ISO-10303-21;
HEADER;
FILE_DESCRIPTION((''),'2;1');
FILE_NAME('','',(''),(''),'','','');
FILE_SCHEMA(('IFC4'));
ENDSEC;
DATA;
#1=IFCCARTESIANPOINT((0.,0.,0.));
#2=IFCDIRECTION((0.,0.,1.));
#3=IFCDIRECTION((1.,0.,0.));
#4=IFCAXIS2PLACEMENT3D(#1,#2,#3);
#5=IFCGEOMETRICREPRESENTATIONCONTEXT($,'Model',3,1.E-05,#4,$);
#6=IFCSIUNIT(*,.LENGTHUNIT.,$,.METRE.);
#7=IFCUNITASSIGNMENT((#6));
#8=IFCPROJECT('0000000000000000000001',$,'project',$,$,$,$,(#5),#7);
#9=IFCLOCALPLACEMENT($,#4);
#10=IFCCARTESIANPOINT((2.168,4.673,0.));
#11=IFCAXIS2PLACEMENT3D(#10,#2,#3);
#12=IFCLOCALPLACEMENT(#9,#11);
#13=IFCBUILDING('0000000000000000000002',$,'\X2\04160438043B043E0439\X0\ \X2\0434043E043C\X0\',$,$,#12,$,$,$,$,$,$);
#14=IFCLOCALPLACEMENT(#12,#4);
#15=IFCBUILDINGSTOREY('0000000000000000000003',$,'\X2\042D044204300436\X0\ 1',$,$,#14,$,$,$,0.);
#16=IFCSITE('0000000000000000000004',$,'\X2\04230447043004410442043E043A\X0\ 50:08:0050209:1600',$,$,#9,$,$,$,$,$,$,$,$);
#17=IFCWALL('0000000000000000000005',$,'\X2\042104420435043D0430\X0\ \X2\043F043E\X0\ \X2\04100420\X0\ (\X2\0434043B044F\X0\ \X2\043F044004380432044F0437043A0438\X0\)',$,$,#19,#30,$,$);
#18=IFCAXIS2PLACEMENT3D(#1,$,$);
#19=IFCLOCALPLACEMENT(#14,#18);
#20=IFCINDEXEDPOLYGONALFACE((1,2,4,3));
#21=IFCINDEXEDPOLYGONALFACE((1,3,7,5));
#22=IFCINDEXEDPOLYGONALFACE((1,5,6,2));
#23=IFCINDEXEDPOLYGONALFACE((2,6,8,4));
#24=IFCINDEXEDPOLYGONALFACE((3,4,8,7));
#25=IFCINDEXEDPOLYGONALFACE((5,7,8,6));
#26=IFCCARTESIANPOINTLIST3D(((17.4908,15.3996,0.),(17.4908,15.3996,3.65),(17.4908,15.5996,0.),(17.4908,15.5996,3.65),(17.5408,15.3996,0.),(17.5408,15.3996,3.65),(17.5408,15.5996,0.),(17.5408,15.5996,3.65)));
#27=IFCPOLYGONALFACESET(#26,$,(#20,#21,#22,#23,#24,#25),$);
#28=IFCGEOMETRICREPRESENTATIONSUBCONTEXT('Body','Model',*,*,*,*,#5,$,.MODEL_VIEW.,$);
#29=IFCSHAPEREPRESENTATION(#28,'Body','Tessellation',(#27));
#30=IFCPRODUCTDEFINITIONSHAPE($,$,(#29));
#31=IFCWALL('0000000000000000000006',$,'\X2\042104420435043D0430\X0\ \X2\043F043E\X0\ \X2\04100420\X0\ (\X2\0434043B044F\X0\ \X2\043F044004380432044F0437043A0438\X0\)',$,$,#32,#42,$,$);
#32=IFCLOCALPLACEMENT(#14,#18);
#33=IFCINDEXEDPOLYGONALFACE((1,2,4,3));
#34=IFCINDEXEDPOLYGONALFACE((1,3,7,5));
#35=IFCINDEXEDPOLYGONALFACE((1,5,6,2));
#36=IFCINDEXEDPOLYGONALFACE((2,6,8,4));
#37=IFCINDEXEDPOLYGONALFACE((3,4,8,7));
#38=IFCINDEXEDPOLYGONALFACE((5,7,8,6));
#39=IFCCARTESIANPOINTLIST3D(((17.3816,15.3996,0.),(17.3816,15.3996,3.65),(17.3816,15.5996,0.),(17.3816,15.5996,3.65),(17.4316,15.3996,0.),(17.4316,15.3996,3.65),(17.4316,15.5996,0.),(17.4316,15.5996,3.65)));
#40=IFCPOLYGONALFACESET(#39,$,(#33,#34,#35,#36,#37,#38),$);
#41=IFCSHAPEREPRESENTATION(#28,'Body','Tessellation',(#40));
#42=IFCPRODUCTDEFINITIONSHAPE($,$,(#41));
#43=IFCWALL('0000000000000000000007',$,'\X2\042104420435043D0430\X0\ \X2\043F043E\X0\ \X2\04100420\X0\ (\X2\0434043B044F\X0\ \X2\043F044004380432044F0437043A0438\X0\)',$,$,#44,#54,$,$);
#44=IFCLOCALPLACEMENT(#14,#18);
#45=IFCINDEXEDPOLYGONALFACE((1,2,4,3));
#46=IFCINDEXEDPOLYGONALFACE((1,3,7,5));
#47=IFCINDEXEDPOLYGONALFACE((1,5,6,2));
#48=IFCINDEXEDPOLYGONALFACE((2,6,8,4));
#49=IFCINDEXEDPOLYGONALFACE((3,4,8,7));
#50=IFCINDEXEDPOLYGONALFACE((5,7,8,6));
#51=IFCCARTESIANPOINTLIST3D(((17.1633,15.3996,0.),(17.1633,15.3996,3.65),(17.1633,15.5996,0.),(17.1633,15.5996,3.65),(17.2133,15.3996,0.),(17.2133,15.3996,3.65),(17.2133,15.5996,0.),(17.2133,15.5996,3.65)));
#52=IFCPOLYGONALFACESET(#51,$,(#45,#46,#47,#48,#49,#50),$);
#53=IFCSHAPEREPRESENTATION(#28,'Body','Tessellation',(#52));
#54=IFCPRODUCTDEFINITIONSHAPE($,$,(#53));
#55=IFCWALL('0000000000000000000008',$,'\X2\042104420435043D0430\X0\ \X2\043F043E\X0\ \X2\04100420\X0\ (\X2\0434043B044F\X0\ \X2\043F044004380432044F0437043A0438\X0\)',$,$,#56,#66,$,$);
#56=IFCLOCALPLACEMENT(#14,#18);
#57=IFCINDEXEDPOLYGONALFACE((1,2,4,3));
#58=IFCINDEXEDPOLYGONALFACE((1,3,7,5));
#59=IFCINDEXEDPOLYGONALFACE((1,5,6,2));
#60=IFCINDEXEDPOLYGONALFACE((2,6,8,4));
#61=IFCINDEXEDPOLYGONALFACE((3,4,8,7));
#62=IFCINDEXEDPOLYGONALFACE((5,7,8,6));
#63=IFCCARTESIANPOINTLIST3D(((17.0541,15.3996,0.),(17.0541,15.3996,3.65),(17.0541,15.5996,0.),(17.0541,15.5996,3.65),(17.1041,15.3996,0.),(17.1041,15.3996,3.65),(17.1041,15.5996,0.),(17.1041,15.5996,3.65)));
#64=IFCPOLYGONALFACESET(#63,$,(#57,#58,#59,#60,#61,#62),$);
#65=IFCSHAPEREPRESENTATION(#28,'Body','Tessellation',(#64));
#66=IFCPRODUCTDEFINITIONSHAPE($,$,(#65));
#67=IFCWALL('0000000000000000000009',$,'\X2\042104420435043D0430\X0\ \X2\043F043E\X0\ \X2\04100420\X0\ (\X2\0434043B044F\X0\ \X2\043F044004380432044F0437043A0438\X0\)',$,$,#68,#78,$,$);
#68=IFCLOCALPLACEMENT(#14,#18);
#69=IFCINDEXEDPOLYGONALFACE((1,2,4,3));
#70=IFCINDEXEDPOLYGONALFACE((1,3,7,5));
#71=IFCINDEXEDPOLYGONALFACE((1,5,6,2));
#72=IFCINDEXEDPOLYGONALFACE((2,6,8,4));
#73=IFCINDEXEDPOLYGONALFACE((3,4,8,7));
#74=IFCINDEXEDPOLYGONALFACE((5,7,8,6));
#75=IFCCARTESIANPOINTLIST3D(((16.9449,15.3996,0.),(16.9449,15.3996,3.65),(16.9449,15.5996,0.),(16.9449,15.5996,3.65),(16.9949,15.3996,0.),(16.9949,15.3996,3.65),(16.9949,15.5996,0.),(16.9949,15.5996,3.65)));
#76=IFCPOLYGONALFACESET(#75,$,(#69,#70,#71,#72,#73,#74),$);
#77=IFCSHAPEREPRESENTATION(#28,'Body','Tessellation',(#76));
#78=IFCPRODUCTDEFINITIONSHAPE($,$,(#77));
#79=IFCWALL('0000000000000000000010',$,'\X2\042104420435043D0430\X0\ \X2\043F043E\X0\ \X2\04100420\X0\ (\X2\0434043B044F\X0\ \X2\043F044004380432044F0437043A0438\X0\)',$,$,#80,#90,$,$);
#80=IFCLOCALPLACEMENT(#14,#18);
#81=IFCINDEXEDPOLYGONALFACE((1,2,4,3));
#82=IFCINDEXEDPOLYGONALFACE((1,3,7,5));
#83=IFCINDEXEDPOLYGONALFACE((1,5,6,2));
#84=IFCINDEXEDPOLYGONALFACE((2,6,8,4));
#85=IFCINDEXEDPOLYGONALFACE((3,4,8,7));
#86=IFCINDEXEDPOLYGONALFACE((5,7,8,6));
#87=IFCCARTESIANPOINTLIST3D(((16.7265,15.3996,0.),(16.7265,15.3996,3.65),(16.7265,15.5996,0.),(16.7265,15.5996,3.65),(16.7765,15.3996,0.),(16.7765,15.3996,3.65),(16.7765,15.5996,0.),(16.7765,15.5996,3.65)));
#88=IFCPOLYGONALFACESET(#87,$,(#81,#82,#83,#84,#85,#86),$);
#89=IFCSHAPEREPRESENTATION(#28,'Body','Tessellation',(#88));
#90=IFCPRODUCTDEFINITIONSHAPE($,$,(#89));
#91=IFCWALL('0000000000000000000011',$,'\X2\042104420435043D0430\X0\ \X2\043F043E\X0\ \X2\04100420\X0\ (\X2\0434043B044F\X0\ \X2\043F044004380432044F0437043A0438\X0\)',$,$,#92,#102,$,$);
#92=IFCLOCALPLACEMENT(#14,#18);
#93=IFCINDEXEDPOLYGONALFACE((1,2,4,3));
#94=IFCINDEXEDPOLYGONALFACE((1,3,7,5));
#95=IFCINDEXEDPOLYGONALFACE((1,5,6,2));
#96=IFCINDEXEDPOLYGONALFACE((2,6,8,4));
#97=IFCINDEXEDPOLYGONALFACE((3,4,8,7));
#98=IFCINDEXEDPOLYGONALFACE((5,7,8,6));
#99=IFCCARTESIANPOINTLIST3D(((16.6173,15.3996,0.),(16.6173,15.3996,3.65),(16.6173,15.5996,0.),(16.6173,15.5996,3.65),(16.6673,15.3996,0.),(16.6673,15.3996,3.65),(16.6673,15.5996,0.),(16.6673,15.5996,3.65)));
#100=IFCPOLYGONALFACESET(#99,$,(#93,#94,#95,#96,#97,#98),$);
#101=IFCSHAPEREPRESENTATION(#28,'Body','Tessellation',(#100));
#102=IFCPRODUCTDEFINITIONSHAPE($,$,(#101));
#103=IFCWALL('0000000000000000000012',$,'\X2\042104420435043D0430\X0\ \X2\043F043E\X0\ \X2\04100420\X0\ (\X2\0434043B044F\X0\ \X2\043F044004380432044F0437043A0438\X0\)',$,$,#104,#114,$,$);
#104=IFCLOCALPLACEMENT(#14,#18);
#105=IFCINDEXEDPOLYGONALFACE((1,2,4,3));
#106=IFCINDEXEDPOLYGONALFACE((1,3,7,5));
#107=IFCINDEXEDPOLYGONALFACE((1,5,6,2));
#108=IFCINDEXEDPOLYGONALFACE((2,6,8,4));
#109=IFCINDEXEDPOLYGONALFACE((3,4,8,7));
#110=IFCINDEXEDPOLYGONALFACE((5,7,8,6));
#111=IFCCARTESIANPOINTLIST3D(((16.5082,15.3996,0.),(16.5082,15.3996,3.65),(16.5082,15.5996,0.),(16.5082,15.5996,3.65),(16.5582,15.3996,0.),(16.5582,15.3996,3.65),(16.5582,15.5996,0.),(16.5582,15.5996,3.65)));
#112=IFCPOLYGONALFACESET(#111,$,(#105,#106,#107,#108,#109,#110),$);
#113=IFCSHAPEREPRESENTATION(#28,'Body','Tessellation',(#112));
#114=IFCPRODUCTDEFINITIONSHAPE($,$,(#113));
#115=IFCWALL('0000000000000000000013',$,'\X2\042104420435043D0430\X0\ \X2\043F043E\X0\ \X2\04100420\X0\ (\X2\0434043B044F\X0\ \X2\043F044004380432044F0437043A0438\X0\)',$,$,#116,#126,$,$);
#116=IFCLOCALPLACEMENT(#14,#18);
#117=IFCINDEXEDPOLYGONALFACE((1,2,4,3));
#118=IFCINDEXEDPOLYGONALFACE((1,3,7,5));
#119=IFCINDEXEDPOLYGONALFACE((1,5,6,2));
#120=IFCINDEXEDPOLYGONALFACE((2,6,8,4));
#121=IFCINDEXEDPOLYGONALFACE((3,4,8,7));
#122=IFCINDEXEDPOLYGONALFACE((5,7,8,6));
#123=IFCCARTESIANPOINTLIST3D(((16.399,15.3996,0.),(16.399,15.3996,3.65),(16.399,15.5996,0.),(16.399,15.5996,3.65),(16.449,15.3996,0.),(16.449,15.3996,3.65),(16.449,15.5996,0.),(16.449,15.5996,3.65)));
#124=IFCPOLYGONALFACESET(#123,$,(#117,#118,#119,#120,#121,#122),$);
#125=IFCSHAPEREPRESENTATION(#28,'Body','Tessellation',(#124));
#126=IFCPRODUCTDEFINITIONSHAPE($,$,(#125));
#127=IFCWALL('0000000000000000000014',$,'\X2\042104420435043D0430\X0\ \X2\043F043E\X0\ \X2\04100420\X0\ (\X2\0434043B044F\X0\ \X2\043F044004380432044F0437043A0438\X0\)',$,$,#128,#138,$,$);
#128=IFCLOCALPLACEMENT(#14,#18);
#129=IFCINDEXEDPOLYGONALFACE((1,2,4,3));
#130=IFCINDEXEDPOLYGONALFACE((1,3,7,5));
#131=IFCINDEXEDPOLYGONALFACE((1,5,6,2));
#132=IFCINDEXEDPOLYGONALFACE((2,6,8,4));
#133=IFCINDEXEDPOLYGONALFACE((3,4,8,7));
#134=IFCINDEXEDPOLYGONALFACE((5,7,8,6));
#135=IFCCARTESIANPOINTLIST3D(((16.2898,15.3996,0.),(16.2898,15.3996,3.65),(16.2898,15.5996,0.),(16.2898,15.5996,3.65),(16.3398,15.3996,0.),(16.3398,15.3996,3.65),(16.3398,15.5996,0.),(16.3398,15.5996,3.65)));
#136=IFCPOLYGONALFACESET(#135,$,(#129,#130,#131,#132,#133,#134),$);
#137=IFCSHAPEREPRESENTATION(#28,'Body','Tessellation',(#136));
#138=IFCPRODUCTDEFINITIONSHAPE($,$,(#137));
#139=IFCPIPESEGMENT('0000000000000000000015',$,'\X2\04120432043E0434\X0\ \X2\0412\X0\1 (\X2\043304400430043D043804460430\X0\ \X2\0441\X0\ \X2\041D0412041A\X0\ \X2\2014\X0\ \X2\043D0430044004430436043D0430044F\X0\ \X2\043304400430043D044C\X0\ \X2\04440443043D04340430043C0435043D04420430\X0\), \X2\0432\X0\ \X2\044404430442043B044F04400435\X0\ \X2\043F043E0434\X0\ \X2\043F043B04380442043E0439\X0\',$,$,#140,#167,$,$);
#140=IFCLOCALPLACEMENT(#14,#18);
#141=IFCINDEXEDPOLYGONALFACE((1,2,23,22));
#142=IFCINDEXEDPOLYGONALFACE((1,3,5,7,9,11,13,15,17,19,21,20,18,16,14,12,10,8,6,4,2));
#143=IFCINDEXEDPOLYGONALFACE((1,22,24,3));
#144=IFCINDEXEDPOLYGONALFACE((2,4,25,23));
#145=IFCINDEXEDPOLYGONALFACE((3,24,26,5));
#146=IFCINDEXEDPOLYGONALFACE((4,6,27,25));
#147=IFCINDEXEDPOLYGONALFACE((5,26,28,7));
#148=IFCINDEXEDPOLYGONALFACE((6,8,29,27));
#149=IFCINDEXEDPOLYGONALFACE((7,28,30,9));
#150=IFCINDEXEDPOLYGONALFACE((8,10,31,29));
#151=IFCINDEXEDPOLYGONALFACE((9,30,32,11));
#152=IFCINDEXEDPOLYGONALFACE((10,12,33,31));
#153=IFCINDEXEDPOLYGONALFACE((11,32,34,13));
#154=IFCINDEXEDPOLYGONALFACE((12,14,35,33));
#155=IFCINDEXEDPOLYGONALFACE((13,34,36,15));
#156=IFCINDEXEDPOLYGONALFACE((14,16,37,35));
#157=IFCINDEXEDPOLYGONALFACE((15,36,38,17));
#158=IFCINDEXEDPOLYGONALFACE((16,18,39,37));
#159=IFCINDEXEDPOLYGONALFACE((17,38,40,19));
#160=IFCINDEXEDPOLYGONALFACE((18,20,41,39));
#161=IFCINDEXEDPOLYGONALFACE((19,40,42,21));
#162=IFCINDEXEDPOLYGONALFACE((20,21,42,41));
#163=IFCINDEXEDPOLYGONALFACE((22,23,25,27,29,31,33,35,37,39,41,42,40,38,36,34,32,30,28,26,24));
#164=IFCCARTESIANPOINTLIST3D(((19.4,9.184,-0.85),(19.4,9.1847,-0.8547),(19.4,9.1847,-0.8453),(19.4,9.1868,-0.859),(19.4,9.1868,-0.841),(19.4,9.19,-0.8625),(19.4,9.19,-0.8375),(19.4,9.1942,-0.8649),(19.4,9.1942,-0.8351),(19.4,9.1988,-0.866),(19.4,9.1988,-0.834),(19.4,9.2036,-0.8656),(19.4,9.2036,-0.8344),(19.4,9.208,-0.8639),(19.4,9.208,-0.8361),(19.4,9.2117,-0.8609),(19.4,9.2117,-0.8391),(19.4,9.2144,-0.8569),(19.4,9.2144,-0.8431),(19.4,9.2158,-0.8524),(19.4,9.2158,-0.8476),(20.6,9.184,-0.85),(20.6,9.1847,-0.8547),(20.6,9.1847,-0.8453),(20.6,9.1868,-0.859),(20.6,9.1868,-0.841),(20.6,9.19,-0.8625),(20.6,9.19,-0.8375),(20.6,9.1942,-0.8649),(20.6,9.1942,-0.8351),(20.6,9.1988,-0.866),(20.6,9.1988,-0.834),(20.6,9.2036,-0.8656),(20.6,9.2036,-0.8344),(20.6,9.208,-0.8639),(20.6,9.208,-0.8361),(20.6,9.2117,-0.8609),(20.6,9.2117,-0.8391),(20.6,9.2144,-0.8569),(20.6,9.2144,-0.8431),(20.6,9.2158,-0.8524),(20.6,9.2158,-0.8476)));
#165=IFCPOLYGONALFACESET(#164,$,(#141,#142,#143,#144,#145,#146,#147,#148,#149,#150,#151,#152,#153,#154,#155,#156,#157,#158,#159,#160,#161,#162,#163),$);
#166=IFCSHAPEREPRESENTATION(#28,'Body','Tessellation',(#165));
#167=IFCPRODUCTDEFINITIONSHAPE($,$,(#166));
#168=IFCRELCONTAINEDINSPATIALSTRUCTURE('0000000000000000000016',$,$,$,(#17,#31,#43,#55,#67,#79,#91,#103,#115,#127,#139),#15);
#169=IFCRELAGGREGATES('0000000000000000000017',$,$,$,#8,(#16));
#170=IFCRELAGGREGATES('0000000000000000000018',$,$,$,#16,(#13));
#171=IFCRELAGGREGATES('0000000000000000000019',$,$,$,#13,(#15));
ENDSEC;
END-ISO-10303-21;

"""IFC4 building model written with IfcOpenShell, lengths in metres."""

from ifc_helpers import new_model, si_unit, frame, origin_with_axes, origin_2d, place, context, subcontext, project, spatial, polyline, circle, outline, extrude, element, save


model = new_model("IFC4")

# Units and contexts
model_context = context("Model", 3, precision=1e-05, world=origin_with_axes())
body_context = subcontext(model_context, "Body", "Model", "MODEL_VIEW")
ifc_project = project(units=[si_unit("LENGTHUNIT", "METRE")], contexts=[model_context])

# Site, building, storey
site_placement = place(None, origin_with_axes())
site = spatial("IfcSite", under=ifc_project, at=site_placement, Name="Участок 50:08:0050209:1600")
building_placement = place(site_placement, frame((2.168, 4.673, 0.0), z_axis=(0.0, 0.0, 1.0), x_axis=(1.0, 0.0, 0.0)))
building = spatial("IfcBuilding", under=site, at=building_placement, Name="Жилой дом")
storey_placement = place(building_placement, origin_with_axes())
storey = spatial("IfcBuildingStorey", under=building, at=storey_placement, Name="Этаж 1", Elevation=0.0)

# Walls
wall_1_placement = place(storey_placement, origin_with_axes())
element("IfcWall", 1, at=wall_1_placement, inside=storey, Name="Стена по АР (для привязки)", context=body_context, shape_type="SweptSolid", body=[
    extrude(outline(polyline([(17.5408, 15.5996), (17.5408, 15.3996), (17.4908, 15.3996), (17.4908, 15.5996), (17.5408, 15.5996)])), origin_with_axes(), (0.0, 0.0, 1.0), 3.65),
])
wall_2_placement = place(storey_placement, origin_with_axes())
element("IfcWall", 2, at=wall_2_placement, inside=storey, Name="Стена по АР (для привязки)", context=body_context, shape_type="SweptSolid", body=[
    extrude(outline(polyline([(17.4316, 15.5996), (17.4316, 15.3996), (17.3816, 15.3996), (17.3816, 15.5996), (17.4316, 15.5996)])), origin_with_axes(), (0.0, 0.0, 1.0), 3.65),
])
wall_3_placement = place(storey_placement, origin_with_axes())
element("IfcWall", 3, at=wall_3_placement, inside=storey, Name="Стена по АР (для привязки)", context=body_context, shape_type="SweptSolid", body=[
    extrude(outline(polyline([(17.2133, 15.5996), (17.2133, 15.3996), (17.1633, 15.3996), (17.1633, 15.5996), (17.2133, 15.5996)])), origin_with_axes(), (0.0, 0.0, 1.0), 3.65),
])
wall_4_placement = place(storey_placement, origin_with_axes())
element("IfcWall", 4, at=wall_4_placement, inside=storey, Name="Стена по АР (для привязки)", context=body_context, shape_type="SweptSolid", body=[
    extrude(outline(polyline([(17.1041, 15.3996), (17.0541, 15.3996), (17.0541, 15.5996), (17.1041, 15.5996), (17.1041, 15.3996)])), origin_with_axes(), (0.0, 0.0, 1.0), 3.65),
])
wall_5_placement = place(storey_placement, origin_with_axes())
element("IfcWall", 5, at=wall_5_placement, inside=storey, Name="Стена по АР (для привязки)", context=body_context, shape_type="SweptSolid", body=[
    extrude(outline(polyline([(16.9949, 15.3996), (16.9449, 15.3996), (16.9449, 15.5996), (16.9949, 15.5996), (16.9949, 15.3996)])), origin_with_axes(), (0.0, 0.0, 1.0), 3.65),
])
wall_6_placement = place(storey_placement, origin_with_axes())
element("IfcWall", 6, at=wall_6_placement, inside=storey, Name="Стена по АР (для привязки)", context=body_context, shape_type="SweptSolid", body=[
    extrude(outline(polyline([(16.7765, 15.5996), (16.7765, 15.3996), (16.7265, 15.3996), (16.7265, 15.5996), (16.7765, 15.5996)])), origin_with_axes(), (0.0, 0.0, 1.0), 3.65),
])
wall_7_placement = place(storey_placement, origin_with_axes())
element("IfcWall", 7, at=wall_7_placement, inside=storey, Name="Стена по АР (для привязки)", context=body_context, shape_type="SweptSolid", body=[
    extrude(outline(polyline([(16.6673, 15.3996), (16.6173, 15.3996), (16.6173, 15.5996), (16.6673, 15.5996), (16.6673, 15.3996)])), origin_with_axes(), (0.0, 0.0, 1.0), 3.65),
])
wall_8_placement = place(storey_placement, origin_with_axes())
element("IfcWall", 8, at=wall_8_placement, inside=storey, Name="Стена по АР (для привязки)", context=body_context, shape_type="SweptSolid", body=[
    extrude(outline(polyline([(16.5582, 15.3996), (16.5082, 15.3996), (16.5082, 15.5996), (16.5582, 15.5996), (16.5582, 15.3996)])), origin_with_axes(), (0.0, 0.0, 1.0), 3.65),
])
wall_9_placement = place(storey_placement, origin_with_axes())
element("IfcWall", 9, at=wall_9_placement, inside=storey, Name="Стена по АР (для привязки)", context=body_context, shape_type="SweptSolid", body=[
    extrude(outline(polyline([(16.449, 15.5996), (16.449, 15.3996), (16.399, 15.3996), (16.399, 15.5996), (16.449, 15.5996)])), origin_with_axes(), (0.0, 0.0, 1.0), 3.65),
])
wall_10_placement = place(storey_placement, origin_with_axes())
element("IfcWall", 10, at=wall_10_placement, inside=storey, Name="Стена по АР (для привязки)", context=body_context, shape_type="SweptSolid", body=[
    extrude(outline(polyline([(16.3398, 15.3996), (16.2898, 15.3996), (16.2898, 15.5996), (16.3398, 15.5996), (16.3398, 15.3996)])), origin_with_axes(), (0.0, 0.0, 1.0), 3.65),
])

# Pipe segment
pipe_segment_1_placement = place(storey_placement, origin_with_axes())
element("IfcPipeSegment", 11, at=pipe_segment_1_placement, inside=storey, Name="Ввод В1 (граница с НВК — наружная грань фундамента), в футляре под плитой", context=body_context, shape_type="SweptSolid", body=[
    extrude(circle(Radius=0.016, at=origin_2d()), frame((20.6, 9.2, -0.85), z_axis=(-1.0, 0.0, 0.0), x_axis=(0.0, -1.0, 0.0)), (0.0, 0.0, 1.0), 1.2),
])

save(model, "model.ifc")
